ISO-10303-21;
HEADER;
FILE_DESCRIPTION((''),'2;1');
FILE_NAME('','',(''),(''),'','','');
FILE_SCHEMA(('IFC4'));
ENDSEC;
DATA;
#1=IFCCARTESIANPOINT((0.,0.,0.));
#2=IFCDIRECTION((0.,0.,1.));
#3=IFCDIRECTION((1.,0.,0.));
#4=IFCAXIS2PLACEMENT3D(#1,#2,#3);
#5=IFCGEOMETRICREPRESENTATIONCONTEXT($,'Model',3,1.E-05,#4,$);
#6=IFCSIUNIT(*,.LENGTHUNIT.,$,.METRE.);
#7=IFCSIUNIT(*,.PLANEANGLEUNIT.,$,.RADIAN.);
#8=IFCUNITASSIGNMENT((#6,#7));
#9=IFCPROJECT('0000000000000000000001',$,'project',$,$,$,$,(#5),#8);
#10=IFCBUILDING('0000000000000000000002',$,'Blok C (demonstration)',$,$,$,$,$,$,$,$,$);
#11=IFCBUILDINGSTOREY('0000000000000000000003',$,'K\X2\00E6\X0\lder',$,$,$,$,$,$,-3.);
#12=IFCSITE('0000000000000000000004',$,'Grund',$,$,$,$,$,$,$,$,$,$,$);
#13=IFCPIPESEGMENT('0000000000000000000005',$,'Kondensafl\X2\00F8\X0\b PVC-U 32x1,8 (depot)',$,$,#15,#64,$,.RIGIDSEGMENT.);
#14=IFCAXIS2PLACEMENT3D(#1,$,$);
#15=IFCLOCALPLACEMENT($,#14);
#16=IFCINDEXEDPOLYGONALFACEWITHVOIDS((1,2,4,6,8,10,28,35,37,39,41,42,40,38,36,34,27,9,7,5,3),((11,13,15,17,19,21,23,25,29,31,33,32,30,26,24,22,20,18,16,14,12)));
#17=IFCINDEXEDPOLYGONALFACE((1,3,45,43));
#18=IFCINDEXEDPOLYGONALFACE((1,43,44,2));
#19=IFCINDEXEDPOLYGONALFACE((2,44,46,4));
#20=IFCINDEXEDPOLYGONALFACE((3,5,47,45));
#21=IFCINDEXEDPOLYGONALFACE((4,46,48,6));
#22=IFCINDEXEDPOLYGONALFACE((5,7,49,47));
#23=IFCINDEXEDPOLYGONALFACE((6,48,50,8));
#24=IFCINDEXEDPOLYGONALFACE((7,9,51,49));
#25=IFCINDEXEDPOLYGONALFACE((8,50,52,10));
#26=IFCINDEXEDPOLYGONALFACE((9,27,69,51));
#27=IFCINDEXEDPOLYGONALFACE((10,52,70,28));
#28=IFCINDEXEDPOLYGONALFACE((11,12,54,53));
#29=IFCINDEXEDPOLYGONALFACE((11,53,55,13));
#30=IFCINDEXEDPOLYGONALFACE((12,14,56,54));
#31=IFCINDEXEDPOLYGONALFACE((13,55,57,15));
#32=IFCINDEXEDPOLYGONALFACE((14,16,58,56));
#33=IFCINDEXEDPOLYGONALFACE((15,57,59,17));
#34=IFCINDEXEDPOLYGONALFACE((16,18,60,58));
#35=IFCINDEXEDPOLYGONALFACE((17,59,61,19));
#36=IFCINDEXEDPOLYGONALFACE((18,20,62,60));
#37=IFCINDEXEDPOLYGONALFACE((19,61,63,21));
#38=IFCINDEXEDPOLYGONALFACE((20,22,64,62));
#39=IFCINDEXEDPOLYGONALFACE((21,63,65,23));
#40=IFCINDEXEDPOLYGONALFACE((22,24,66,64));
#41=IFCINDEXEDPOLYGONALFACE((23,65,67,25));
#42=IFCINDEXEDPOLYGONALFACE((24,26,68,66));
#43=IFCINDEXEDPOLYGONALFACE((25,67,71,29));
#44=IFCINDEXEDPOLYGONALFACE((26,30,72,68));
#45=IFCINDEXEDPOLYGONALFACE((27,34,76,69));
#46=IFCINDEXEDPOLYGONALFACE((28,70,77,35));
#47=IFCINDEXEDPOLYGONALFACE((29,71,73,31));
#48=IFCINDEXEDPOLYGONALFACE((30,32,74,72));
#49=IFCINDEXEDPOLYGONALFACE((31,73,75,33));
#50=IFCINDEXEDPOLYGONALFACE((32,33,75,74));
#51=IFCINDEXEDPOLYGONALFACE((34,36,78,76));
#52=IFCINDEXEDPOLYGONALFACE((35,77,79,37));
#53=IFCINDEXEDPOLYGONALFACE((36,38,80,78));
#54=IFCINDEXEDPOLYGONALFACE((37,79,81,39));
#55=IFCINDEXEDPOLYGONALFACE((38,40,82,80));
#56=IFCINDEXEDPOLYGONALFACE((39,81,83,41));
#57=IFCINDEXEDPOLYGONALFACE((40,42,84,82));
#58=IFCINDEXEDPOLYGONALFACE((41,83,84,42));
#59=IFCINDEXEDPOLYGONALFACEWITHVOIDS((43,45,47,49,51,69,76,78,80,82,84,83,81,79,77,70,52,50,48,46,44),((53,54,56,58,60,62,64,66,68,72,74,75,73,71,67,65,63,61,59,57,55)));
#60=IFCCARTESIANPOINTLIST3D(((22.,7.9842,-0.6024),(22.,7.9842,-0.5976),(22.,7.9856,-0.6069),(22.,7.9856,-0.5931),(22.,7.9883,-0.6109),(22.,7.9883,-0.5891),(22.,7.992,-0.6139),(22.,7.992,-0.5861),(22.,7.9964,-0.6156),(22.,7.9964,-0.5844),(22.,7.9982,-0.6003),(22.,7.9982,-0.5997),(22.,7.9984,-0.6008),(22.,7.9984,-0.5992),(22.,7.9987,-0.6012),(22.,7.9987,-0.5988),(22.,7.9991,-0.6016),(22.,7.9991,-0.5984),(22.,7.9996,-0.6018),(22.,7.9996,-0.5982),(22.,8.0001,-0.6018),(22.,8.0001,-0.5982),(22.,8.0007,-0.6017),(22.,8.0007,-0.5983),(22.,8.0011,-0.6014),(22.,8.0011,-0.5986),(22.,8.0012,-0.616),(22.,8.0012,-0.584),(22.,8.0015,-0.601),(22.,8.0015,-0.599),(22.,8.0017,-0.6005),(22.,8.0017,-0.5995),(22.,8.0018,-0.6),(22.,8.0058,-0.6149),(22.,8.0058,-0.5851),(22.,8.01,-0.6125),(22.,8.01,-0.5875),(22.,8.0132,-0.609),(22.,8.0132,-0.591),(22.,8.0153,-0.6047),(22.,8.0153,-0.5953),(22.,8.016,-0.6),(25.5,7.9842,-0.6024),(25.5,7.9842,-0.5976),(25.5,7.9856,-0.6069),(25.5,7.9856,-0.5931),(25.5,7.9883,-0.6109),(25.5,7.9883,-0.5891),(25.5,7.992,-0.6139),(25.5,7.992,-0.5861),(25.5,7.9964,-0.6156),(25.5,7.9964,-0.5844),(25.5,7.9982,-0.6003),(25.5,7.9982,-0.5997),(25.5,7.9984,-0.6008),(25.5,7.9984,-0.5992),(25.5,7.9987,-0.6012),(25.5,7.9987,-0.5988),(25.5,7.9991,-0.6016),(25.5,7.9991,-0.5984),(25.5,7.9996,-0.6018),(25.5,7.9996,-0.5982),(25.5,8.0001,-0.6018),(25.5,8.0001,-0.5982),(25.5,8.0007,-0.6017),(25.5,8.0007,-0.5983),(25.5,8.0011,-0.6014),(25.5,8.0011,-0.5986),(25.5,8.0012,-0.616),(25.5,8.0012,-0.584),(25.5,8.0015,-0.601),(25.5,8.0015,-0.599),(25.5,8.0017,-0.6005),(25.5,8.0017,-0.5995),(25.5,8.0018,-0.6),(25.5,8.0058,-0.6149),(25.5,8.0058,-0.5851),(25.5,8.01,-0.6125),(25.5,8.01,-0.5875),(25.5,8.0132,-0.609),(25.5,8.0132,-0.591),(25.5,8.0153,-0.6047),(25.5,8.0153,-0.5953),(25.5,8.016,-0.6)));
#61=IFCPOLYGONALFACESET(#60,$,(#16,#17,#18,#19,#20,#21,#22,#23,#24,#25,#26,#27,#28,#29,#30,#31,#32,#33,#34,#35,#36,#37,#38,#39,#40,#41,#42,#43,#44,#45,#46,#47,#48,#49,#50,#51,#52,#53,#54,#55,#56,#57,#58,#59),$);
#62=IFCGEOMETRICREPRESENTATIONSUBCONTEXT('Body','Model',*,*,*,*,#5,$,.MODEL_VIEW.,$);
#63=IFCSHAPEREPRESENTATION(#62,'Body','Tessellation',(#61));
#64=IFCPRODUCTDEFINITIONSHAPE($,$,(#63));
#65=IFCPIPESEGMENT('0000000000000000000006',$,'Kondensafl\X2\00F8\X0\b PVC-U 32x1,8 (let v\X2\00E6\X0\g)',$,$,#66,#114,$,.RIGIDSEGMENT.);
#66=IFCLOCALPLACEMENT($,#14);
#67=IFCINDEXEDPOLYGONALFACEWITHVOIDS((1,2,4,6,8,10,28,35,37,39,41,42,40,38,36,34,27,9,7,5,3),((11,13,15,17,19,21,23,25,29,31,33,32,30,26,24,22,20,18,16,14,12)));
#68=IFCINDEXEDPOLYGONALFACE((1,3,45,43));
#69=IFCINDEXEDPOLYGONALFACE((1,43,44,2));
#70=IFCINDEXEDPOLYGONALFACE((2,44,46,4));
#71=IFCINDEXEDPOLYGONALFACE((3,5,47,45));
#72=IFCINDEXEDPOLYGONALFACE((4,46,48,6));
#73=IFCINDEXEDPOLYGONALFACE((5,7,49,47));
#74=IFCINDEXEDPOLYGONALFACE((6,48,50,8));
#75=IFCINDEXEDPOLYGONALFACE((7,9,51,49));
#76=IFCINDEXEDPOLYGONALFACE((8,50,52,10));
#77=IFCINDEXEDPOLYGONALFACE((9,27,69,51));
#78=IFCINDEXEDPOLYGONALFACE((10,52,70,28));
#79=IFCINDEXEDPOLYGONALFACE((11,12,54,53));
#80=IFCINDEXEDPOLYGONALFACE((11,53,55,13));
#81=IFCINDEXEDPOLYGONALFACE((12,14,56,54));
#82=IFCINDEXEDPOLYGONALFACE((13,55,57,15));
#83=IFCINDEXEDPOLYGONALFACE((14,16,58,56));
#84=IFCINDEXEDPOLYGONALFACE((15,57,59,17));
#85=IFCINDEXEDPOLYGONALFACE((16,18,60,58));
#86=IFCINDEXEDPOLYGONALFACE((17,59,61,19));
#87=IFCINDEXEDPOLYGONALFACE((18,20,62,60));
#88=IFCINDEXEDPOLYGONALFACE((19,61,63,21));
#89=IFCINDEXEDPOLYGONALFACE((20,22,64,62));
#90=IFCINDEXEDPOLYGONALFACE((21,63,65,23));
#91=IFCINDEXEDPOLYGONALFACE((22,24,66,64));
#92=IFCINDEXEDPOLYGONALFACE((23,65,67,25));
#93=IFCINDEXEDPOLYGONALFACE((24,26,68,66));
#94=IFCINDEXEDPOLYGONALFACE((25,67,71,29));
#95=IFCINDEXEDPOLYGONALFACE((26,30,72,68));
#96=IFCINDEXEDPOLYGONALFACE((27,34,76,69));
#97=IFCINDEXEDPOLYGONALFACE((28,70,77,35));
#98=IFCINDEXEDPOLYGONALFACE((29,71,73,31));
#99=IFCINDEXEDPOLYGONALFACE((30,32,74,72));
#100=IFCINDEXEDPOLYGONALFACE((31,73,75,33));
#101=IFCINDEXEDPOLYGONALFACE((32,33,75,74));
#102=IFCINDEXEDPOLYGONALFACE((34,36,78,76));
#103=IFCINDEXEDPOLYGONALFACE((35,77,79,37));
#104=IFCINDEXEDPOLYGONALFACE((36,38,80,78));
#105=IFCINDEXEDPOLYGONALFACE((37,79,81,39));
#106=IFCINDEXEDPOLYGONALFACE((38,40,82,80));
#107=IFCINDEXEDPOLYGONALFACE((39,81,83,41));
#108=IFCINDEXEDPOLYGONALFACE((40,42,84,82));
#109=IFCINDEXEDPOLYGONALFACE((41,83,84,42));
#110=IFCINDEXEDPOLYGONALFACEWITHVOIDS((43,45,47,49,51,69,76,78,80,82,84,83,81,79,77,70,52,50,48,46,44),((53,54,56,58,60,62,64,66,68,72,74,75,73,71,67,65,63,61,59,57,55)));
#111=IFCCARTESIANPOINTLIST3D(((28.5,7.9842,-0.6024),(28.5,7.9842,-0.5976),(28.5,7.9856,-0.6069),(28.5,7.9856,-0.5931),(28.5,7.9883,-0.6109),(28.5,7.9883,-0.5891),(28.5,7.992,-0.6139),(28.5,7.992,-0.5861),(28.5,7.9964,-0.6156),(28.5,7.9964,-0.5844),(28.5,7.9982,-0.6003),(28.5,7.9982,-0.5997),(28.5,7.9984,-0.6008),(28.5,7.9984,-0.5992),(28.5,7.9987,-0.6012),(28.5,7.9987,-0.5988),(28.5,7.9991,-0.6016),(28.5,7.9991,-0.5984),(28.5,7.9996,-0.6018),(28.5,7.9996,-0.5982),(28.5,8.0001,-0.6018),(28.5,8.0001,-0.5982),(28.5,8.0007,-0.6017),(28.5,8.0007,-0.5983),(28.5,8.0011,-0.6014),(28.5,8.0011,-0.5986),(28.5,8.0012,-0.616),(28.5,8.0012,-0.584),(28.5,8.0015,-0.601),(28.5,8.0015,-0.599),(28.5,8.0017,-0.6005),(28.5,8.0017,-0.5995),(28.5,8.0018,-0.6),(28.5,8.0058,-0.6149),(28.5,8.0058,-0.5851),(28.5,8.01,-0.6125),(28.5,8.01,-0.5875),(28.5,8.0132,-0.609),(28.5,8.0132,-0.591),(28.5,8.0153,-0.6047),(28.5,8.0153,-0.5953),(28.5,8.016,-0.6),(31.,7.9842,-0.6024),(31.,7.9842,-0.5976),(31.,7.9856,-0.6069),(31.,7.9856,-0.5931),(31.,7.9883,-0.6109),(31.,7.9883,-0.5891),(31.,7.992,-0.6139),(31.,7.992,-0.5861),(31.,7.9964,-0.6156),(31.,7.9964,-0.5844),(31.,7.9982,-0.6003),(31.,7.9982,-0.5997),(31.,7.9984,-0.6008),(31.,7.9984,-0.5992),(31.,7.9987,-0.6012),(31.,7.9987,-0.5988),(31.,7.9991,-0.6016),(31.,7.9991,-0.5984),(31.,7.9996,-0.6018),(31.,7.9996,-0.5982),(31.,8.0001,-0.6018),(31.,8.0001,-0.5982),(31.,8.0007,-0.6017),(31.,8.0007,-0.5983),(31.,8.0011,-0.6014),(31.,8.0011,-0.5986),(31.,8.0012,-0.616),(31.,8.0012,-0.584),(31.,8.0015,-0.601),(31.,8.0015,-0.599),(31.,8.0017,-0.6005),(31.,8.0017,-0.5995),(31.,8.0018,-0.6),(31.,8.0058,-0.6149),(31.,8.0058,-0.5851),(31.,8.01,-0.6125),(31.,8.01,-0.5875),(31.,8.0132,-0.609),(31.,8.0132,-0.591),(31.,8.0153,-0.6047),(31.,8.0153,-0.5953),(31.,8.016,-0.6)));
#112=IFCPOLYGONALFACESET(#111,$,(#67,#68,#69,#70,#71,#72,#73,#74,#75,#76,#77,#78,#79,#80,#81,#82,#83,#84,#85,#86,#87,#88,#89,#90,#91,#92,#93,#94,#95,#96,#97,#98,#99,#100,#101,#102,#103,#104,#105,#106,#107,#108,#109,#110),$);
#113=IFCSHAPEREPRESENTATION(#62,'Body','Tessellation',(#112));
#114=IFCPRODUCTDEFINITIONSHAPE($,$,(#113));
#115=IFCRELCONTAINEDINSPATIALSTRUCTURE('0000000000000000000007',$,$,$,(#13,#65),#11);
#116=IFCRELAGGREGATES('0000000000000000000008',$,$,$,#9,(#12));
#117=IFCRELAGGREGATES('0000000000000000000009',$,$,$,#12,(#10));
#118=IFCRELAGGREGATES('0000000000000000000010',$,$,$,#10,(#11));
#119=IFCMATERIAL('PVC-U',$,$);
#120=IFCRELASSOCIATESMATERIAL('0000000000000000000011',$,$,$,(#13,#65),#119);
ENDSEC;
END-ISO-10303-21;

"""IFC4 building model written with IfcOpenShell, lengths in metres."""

from ifc_helpers import new_model, si_unit, frame, origin_with_axes, place, context, subcontext, project, spatial, hollow_circle, extrude, material, element, save


model = new_model("IFC4")

# Units and contexts
model_context = context("Model", 3, precision=1e-05, world=origin_with_axes())
body_context = subcontext(model_context, "Body", "Model", "MODEL_VIEW")
ifc_project = project(units=[si_unit("LENGTHUNIT", "METRE"), si_unit("PLANEANGLEUNIT", "RADIAN")], contexts=[model_context])

# Site, building, storey
site = spatial("IfcSite", under=ifc_project, Name="Grund")
building = spatial("IfcBuilding", under=site, Name="Blok C (demonstration)")
storey = spatial("IfcBuildingStorey", under=building, Name="Kælder", Elevation=-3.0)

# Pipe segments
ifc_material_1 = material(Name="PVC-U")
pipe_segment_1_placement = place(None, origin_with_axes())
element("IfcPipeSegment", 1, at=pipe_segment_1_placement, inside=storey, material=ifc_material_1, Name="Kondensafløb PVC-U 32x1,8 (depot)", PredefinedType="RIGIDSEGMENT", context=body_context, shape_type="SweptSolid", body=[
    extrude(hollow_circle(Radius=0.016, WallThickness=0.0142), frame((22.0, 8.0, -0.6), z_axis=(1.0, 0.0, 0.0), x_axis=(0.0, 1.0, 0.0)), (0.0, 0.0, 1.0), 3.5),
])
pipe_segment_2_placement = place(None, origin_with_axes())
element("IfcPipeSegment", 2, at=pipe_segment_2_placement, inside=storey, material=ifc_material_1, Name="Kondensafløb PVC-U 32x1,8 (let væg)", PredefinedType="RIGIDSEGMENT", context=body_context, shape_type="SweptSolid", body=[
    extrude(hollow_circle(Radius=0.016, WallThickness=0.0142), frame((28.5, 8.0, -0.6), z_axis=(1.0, 0.0, 0.0), x_axis=(0.0, 1.0, 0.0)), (0.0, 0.0, 1.0), 2.5),
])

save(model, "model.ifc")
